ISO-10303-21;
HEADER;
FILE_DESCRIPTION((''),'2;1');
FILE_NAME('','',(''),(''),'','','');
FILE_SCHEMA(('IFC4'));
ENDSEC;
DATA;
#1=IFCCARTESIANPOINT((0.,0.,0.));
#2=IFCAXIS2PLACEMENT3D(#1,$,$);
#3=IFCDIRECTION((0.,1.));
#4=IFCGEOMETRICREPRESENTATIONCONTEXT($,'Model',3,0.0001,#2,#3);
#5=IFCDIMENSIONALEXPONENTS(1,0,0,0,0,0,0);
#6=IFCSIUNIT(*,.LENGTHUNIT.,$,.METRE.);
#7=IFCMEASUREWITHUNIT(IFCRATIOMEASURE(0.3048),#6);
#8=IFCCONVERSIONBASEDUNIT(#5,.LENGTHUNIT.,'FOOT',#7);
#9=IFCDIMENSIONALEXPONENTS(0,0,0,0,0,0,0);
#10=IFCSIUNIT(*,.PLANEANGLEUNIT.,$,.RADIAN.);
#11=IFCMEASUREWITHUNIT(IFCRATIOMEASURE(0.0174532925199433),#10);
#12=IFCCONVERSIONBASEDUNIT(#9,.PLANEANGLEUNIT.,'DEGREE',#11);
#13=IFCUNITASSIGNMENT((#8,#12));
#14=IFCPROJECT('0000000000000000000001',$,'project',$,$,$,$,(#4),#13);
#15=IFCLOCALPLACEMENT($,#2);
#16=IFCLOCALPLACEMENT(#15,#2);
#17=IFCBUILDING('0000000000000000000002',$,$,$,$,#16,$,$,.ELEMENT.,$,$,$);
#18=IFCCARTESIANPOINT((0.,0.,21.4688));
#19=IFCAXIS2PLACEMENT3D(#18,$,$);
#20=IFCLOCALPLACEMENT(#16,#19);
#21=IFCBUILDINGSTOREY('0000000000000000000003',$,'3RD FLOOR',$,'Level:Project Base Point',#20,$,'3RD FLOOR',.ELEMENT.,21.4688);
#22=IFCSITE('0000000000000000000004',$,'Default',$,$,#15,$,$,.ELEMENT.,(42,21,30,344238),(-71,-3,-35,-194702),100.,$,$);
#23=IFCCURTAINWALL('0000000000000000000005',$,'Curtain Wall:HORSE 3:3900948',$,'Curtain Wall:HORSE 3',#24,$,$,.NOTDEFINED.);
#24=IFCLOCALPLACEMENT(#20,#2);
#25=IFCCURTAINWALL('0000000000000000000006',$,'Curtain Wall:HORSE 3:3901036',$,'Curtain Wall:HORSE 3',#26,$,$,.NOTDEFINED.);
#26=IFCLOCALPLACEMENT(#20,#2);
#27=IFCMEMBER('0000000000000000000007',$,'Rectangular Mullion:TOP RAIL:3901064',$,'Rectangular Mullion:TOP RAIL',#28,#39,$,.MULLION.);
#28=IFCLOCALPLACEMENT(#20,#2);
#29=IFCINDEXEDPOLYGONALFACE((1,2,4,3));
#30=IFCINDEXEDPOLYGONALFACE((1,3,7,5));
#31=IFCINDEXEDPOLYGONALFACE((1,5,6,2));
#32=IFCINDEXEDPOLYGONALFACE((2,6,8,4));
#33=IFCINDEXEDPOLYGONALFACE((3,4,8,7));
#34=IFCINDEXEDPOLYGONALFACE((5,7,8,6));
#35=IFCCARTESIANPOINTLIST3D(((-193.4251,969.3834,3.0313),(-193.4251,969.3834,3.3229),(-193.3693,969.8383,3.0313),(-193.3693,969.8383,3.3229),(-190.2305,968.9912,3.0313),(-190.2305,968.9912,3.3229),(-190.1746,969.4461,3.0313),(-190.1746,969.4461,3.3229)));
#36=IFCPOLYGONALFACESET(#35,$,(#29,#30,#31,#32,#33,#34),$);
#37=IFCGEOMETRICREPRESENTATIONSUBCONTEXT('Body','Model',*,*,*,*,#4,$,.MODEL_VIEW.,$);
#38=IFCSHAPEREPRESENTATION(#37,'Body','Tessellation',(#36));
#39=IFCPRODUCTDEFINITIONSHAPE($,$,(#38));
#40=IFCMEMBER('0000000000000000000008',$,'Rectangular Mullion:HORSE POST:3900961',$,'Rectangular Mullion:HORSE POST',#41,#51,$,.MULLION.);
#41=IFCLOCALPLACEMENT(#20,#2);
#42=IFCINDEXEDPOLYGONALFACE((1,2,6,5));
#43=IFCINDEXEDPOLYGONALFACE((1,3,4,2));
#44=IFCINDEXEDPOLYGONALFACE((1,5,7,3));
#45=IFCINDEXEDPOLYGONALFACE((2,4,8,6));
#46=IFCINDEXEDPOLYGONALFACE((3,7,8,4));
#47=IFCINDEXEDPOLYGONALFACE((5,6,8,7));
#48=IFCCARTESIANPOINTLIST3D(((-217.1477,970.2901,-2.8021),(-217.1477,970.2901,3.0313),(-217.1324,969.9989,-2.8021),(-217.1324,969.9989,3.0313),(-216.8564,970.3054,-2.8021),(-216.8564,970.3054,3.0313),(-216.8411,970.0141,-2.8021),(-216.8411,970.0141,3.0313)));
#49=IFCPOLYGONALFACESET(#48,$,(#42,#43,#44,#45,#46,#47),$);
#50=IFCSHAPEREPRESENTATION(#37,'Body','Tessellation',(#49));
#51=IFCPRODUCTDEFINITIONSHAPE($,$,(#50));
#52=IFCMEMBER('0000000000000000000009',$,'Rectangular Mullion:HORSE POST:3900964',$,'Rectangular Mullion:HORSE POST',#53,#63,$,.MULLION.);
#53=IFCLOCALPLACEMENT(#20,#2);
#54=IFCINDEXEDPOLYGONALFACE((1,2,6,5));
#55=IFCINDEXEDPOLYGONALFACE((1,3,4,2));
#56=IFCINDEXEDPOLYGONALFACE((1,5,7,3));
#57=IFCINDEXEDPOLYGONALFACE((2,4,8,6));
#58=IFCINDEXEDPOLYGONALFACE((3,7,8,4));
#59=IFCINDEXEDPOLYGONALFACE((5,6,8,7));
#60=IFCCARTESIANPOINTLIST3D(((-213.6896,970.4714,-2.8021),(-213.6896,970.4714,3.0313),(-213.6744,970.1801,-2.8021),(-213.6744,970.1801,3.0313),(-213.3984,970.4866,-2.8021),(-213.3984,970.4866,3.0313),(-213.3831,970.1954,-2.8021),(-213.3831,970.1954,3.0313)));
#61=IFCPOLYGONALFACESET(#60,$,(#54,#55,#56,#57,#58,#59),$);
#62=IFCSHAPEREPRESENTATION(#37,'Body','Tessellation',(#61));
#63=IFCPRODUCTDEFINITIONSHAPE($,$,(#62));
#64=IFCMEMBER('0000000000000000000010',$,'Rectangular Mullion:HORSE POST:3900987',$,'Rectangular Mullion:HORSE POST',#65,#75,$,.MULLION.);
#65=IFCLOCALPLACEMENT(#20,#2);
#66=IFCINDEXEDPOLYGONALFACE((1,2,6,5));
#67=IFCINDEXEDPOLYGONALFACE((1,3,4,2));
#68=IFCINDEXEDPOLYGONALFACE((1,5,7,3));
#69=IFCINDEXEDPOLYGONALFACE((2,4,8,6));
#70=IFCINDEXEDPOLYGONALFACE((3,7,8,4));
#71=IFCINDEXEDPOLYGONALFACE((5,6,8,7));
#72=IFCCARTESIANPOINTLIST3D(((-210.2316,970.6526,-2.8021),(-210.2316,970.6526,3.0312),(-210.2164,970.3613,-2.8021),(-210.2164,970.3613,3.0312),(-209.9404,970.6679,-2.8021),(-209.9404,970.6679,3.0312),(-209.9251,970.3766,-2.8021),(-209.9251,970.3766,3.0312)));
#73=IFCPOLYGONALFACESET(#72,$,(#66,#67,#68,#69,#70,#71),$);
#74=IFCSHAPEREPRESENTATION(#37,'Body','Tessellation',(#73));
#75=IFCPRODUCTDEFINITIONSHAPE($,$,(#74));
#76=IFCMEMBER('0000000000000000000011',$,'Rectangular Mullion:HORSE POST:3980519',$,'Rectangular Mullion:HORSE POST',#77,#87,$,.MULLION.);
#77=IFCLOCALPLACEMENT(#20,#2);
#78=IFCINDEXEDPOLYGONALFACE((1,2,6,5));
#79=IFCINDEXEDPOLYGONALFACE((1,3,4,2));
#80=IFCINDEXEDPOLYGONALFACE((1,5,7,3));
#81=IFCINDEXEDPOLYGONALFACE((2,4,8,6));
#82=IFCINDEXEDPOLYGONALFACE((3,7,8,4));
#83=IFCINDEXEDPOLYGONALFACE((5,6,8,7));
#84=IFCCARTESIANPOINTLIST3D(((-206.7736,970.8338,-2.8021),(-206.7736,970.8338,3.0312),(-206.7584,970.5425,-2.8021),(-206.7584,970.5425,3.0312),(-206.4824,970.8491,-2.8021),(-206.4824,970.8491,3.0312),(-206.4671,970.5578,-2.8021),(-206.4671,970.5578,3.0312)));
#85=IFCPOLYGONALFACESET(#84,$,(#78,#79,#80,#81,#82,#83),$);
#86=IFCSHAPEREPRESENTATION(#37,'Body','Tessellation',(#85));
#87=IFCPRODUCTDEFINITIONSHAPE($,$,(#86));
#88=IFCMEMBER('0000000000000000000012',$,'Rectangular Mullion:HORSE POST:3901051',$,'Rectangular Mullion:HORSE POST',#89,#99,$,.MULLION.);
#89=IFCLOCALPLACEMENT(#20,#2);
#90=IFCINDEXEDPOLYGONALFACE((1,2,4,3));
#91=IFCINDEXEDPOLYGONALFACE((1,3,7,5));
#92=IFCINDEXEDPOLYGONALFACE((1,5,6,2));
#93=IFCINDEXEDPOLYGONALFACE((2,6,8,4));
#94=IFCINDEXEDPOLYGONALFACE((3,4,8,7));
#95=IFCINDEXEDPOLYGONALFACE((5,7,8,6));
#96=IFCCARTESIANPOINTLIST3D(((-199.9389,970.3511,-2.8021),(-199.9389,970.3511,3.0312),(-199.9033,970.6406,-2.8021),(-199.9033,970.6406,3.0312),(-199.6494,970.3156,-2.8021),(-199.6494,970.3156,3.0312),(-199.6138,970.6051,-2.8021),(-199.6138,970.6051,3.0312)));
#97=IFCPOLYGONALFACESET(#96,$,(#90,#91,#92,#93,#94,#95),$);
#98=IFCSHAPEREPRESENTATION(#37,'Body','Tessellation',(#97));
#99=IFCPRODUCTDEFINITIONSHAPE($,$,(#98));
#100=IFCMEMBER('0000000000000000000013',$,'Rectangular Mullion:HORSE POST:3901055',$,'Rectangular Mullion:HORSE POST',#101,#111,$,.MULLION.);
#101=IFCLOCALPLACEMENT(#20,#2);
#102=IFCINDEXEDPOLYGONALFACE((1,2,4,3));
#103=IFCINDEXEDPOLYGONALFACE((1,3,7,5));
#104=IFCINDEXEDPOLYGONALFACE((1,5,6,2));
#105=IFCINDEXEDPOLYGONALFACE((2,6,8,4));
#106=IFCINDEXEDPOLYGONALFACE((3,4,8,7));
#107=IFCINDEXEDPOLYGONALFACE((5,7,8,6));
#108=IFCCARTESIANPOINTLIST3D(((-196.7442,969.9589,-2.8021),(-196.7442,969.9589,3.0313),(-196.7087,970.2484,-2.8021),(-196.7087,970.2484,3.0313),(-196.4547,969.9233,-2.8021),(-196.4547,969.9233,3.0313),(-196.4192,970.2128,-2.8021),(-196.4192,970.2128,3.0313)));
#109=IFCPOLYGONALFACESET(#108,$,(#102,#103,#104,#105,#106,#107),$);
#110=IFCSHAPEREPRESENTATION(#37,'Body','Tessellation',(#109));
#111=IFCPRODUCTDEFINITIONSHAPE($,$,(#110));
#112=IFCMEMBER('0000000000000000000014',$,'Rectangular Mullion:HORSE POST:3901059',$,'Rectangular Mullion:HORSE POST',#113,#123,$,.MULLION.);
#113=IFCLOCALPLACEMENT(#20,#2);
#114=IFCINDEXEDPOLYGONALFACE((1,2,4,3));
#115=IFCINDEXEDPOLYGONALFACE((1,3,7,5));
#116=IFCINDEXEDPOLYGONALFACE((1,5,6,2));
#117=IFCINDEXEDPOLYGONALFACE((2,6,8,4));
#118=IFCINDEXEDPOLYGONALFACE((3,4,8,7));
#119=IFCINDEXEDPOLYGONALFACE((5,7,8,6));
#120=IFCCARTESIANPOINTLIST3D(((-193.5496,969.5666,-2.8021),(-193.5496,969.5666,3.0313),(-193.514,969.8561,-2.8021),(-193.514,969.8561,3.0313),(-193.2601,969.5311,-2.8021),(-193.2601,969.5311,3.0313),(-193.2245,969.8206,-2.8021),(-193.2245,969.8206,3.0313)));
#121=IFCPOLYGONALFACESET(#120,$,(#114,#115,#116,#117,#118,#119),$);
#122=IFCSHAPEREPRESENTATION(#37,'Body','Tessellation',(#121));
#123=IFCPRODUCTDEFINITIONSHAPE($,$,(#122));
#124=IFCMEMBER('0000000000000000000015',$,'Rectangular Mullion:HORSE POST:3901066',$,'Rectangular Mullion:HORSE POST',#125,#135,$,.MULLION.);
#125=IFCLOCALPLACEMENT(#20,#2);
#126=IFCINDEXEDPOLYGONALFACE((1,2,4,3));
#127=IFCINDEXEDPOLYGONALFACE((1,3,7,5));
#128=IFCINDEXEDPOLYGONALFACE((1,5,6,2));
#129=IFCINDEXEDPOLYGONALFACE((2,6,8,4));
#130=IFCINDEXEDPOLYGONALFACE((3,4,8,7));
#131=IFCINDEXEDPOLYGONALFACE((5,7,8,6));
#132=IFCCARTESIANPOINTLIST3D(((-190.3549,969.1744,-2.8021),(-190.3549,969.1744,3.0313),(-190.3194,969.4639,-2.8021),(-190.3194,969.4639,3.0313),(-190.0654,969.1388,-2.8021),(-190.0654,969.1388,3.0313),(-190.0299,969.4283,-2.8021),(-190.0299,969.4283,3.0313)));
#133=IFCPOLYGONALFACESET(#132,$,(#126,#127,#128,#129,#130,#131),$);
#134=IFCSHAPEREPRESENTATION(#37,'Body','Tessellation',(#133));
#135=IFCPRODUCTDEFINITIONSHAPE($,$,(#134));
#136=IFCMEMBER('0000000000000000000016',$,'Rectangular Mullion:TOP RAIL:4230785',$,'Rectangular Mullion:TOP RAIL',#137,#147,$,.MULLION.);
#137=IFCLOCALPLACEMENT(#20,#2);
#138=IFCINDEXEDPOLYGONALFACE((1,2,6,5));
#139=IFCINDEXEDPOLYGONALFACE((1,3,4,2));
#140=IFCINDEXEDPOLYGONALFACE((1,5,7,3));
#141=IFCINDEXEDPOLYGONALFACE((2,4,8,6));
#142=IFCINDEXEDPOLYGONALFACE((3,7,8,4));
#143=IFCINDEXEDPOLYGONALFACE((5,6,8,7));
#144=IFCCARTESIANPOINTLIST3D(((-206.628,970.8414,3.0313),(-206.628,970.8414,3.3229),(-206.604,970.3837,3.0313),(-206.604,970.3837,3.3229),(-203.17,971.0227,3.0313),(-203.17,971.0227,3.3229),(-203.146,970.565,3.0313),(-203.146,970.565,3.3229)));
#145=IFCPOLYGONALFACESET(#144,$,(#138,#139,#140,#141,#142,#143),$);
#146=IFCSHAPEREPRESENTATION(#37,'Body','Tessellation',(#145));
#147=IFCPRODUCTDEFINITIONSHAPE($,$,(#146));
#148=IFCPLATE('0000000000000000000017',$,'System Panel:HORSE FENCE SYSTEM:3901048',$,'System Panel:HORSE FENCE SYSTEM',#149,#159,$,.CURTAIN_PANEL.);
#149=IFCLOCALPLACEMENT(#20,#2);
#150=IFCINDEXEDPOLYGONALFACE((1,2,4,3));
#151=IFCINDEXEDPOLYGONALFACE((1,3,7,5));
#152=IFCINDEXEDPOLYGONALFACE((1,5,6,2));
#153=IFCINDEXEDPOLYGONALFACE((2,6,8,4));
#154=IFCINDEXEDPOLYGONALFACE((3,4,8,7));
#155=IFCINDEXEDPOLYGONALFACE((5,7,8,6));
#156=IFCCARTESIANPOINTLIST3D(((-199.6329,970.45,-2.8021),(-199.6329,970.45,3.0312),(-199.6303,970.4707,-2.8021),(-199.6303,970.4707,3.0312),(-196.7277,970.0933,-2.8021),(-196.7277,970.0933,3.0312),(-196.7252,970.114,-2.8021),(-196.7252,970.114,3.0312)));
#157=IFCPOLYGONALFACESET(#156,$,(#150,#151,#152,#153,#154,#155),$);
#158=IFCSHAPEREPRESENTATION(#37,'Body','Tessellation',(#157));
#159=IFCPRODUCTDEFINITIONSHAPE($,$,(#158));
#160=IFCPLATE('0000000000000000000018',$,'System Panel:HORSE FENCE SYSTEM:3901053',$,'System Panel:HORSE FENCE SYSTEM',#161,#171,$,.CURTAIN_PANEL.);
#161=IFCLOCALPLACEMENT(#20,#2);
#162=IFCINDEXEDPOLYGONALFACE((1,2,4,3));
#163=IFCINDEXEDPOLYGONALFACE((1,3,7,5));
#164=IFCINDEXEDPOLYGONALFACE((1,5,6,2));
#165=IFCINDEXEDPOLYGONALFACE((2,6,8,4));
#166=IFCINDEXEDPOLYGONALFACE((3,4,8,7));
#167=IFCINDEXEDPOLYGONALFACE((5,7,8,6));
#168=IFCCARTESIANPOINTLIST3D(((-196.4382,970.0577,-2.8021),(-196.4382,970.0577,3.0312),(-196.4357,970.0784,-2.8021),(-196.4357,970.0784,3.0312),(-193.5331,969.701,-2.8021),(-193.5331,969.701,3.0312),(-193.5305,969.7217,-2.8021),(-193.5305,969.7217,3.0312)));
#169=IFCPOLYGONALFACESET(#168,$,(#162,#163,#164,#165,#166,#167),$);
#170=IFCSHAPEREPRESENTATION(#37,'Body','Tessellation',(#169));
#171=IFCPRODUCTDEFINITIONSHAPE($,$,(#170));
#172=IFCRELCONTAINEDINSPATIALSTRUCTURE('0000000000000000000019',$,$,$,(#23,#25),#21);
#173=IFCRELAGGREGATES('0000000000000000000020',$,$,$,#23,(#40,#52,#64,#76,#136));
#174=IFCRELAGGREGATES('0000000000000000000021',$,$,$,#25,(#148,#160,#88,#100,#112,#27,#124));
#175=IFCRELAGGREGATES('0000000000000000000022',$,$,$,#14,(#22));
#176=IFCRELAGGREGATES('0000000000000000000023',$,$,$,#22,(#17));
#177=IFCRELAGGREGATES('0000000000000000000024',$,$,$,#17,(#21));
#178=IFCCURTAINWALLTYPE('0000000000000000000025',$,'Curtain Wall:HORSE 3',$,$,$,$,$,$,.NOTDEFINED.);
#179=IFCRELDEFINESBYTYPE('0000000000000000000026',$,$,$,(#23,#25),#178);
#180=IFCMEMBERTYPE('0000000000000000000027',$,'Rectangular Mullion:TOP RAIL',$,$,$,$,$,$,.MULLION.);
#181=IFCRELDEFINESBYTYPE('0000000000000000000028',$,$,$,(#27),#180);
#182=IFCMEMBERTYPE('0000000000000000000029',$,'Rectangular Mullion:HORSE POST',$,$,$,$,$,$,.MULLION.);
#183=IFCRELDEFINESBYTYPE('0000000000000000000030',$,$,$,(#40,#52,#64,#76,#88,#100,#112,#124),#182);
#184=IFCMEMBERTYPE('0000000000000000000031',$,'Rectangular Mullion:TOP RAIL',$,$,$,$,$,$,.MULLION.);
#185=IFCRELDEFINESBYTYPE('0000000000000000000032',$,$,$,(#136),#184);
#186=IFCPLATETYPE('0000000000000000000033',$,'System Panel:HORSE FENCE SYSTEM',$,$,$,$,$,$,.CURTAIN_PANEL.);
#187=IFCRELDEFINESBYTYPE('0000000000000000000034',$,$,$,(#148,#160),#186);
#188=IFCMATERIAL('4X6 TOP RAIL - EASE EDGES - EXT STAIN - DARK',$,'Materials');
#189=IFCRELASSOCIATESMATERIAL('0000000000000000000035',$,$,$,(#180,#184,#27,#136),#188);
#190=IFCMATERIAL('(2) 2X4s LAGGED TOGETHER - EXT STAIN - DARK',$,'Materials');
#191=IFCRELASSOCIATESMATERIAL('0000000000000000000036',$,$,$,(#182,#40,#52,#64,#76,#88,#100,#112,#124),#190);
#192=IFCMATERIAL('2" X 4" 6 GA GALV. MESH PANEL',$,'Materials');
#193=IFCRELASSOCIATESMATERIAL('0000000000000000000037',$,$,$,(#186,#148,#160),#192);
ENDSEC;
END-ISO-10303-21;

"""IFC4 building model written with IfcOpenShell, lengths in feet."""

from ifc_helpers import new_model, entity, si_unit, converted_unit, direction, frame, frame_2d, origin, origin_2d_with_axis, place, context, subcontext, project, spatial, rectangle, extrude, source, transform, mapped, material, material_profile, profile_set, profile_usage, type_object, type_shapes, element, aggregate, save


model = new_model("IFC4")

# Units and contexts
model_context = context("Model", 3, precision=0.0001, world=origin(), true_north=direction((0.0, 1.0)))
body_context = subcontext(model_context, "Body", "Model", "MODEL_VIEW")
ifc_project = project(units=[converted_unit("LENGTHUNIT", "FOOT", entity("IfcRatioMeasure", 0.3048), si_unit("LENGTHUNIT", "METRE"), dimensions=[1, 0, 0, 0, 0, 0, 0]), converted_unit("PLANEANGLEUNIT", "DEGREE", entity("IfcRatioMeasure", 0.0174532925199433), si_unit("PLANEANGLEUNIT", "RADIAN"), dimensions=[0, 0, 0, 0, 0, 0, 0])], contexts=[model_context])

# Site, building, storey
site_placement = place(None, origin())
site = spatial("IfcSite", under=ifc_project, at=site_placement, Name="Default", CompositionType="ELEMENT", RefLatitude=(42, 21, 30, 344238), RefLongitude=(-71, -3, -35, -194702), RefElevation=100.0)
building_placement = place(site_placement, origin())
building = spatial("IfcBuilding", under=site, at=building_placement, CompositionType="ELEMENT")
storey_placement = place(building_placement, frame((0.0, 0.0, 21.4688)))
storey = spatial("IfcBuildingStorey", under=building, at=storey_placement, Name="3RD FLOOR", ObjectType="Level:Project Base Point", LongName="3RD FLOOR", CompositionType="ELEMENT", Elevation=21.4688)

# Curtain walls
curtain_wall_type_1 = type_object("IfcCurtainWallType", Name="Curtain Wall:HORSE 3", PredefinedType="NOTDEFINED")
curtain_wall_1_placement = place(storey_placement, frame((0.0, 0.0, -21.4688)))
curtain_wall_1 = element("IfcCurtainWall", 1, at=curtain_wall_1_placement, inside=storey, type_object=curtain_wall_type_1, Name="Curtain Wall:HORSE 3:3900948", ObjectType="Curtain Wall:HORSE 3", PredefinedType="NOTDEFINED")
ifc_material_1 = material(Name="(2) 2X4s LAGGED TOGETHER - EXT STAIN - DARK", Category="Materials")
ifc_material_profile_1 = material_profile(ifc_material_1, rectangle(XDim=0.2917, YDim=0.2917, at=frame_2d((0.0, 0.0), x_axis=(1.0, 0.0))), Name="HORSE POST")
ifc_profile_set_1 = profile_set([ifc_material_profile_1], Name="HORSE POST")
curtain_wall_2_placement = place(storey_placement, frame((0.0, 0.0, -21.4688)))
curtain_wall_2 = element("IfcCurtainWall", 2, at=curtain_wall_2_placement, inside=storey, type_object=curtain_wall_type_1, Name="Curtain Wall:HORSE 3:3901036", ObjectType="Curtain Wall:HORSE 3", PredefinedType="NOTDEFINED")

# Members
ifc_material_2 = material(Name="4X6 TOP RAIL - EASE EDGES - EXT STAIN - DARK", Category="Materials")
ifc_material_profile_2 = material_profile(ifc_material_2, rectangle(XDim=0.4583, YDim=0.2917, at=origin_2d_with_axis()), Name="TOP RAIL")
ifc_profile_set_2 = profile_set([ifc_material_profile_2], Name="TOP RAIL")
member_type_1 = type_object("IfcMemberType", Name="Rectangular Mullion:TOP RAIL", PredefinedType="MULLION", material=ifc_profile_set_2)
shared_shape_1 = source(origin(), body_context, "Body", "SweptSolid", [
    extrude(rectangle(XDim=0.4583, YDim=0.2917, at=origin_2d_with_axis()), frame((-0.1458, -0.0625, -3.2186), z_axis=(0.0, 0.0, 1.0), x_axis=(0.0, -1.0, 0.0)), (0.0, 0.0, 1.0), 3.2186),
])
type_shapes(member_type_1, [shared_shape_1])
ifc_profile_usage_1 = profile_usage(ifc_profile_set_2)
member_1_placement = place(storey_placement, frame((-190.2102, 969.1566, 3.3229), z_axis=(0.992546, -0.121869, 0.0), x_axis=(0.0, 0.0, 1.0)))
member_1 = element("IfcMember", 3, at=member_1_placement, type_object=member_type_1, material=ifc_profile_usage_1, Name="Rectangular Mullion:TOP RAIL:3901064", ObjectType="Rectangular Mullion:TOP RAIL", PredefinedType="MULLION", context=body_context, shape_type="MappedRepresentation", body=[
    mapped(shared_shape_1, transform((0.0, 0.0, 0.0), scale=1.0)),
])
ifc_profile_usage_2 = profile_usage(ifc_profile_set_1)
member_type_2 = type_object("IfcMemberType", Name="Rectangular Mullion:HORSE POST", PredefinedType="MULLION", material=ifc_profile_set_1)
shared_shape_2 = source(origin(), body_context, "Body", "SweptSolid", [
    extrude(rectangle(XDim=0.2917, YDim=0.2917, at=frame_2d((0.0, 0.0), x_axis=(1.0, 0.0))), frame((0.0, -0.1458, -5.8333), z_axis=(0.0, 0.0, 1.0), x_axis=(0.0, -1.0, 0.0)), (0.0, 0.0, 1.0), 5.8333),
])
type_shapes(member_type_2, [shared_shape_2])
member_2_placement = place(storey_placement, frame((-216.9868, 970.0065, -2.8021), z_axis=(0.0, 0.0, -1.0), x_axis=(0.99863, 0.052336, 0.0)))
member_2 = element("IfcMember", 4, at=member_2_placement, type_object=member_type_2, material=ifc_profile_usage_2, Name="Rectangular Mullion:HORSE POST:3900961", ObjectType="Rectangular Mullion:HORSE POST", PredefinedType="MULLION", context=body_context, shape_type="MappedRepresentation", body=[
    mapped(shared_shape_2, transform((0.0, 0.0, 0.0), scale=1.0)),
])
ifc_profile_usage_3 = profile_usage(ifc_profile_set_1)
member_3_placement = place(storey_placement, frame((-213.5287, 970.1877, -2.8021), z_axis=(0.0, 0.0, -1.0), x_axis=(0.99863, 0.052336, 0.0)))
member_3 = element("IfcMember", 5, at=member_3_placement, type_object=member_type_2, material=ifc_profile_usage_3, Name="Rectangular Mullion:HORSE POST:3900964", ObjectType="Rectangular Mullion:HORSE POST", PredefinedType="MULLION", context=body_context, shape_type="MappedRepresentation", body=[
    mapped(shared_shape_2, transform((0.0, 0.0, 0.0), scale=1.0)),
])
ifc_profile_usage_4 = profile_usage(ifc_profile_set_1)
placement = place(building_placement, frame((0.0, 0.0, 10.8021)))
member_4_placement = place(placement, frame((-210.0707, 970.369, 7.8646), z_axis=(0.0, 0.0, -1.0), x_axis=(0.99863, 0.052336, 0.0)))
member_4 = element("IfcMember", 6, at=member_4_placement, type_object=member_type_2, material=ifc_profile_usage_4, Name="Rectangular Mullion:HORSE POST:3900987", ObjectType="Rectangular Mullion:HORSE POST", PredefinedType="MULLION", context=body_context, shape_type="MappedRepresentation", body=[
    mapped(shared_shape_2, transform((0.0, 0.0, 0.0), scale=1.0)),
])
ifc_profile_usage_5 = profile_usage(ifc_profile_set_1)
member_5_placement = place(placement, frame((-206.6127, 970.5502, 7.8646), z_axis=(0.0, 0.0, -1.0), x_axis=(0.99863, 0.052336, 0.0)))
member_5 = element("IfcMember", 7, at=member_5_placement, type_object=member_type_2, material=ifc_profile_usage_5, Name="Rectangular Mullion:HORSE POST:3980519", ObjectType="Rectangular Mullion:HORSE POST", PredefinedType="MULLION", context=body_context, shape_type="MappedRepresentation", body=[
    mapped(shared_shape_2, transform((0.0, 0.0, 0.0), scale=1.0)),
])
ifc_profile_usage_6 = profile_usage(ifc_profile_set_1)
member_6_placement = place(storey_placement, frame((-199.7941, 970.3334, -2.8021), z_axis=(0.0, 0.0, -1.0), x_axis=(0.992546, -0.121869, 0.0)))
member_6 = element("IfcMember", 8, at=member_6_placement, type_object=member_type_2, material=ifc_profile_usage_6, Name="Rectangular Mullion:HORSE POST:3901051", ObjectType="Rectangular Mullion:HORSE POST", PredefinedType="MULLION", context=body_context, shape_type="MappedRepresentation", body=[
    mapped(shared_shape_2, transform((0.0, 0.0, 0.0), scale=1.0)),
])
ifc_profile_usage_7 = profile_usage(ifc_profile_set_1)
member_7_placement = place(storey_placement, frame((-196.5995, 969.9411, -2.8021), z_axis=(0.0, 0.0, -1.0), x_axis=(0.992546, -0.121869, 0.0)))
member_7 = element("IfcMember", 9, at=member_7_placement, type_object=member_type_2, material=ifc_profile_usage_7, Name="Rectangular Mullion:HORSE POST:3901055", ObjectType="Rectangular Mullion:HORSE POST", PredefinedType="MULLION", context=body_context, shape_type="MappedRepresentation", body=[
    mapped(shared_shape_2, transform((0.0, 0.0, 0.0), scale=1.0)),
])
ifc_profile_usage_8 = profile_usage(ifc_profile_set_1)
member_8_placement = place(storey_placement, frame((-193.4048, 969.5489, -2.8021), z_axis=(0.0, 0.0, -1.0), x_axis=(0.992546, -0.121869, 0.0)))
member_8 = element("IfcMember", 10, at=member_8_placement, type_object=member_type_2, material=ifc_profile_usage_8, Name="Rectangular Mullion:HORSE POST:3901059", ObjectType="Rectangular Mullion:HORSE POST", PredefinedType="MULLION", context=body_context, shape_type="MappedRepresentation", body=[
    mapped(shared_shape_2, transform((0.0, 0.0, 0.0), scale=1.0)),
])
ifc_profile_usage_9 = profile_usage(ifc_profile_set_1)
member_9_placement = place(storey_placement, frame((-190.2102, 969.1566, -2.8021), z_axis=(0.0, 0.0, -1.0), x_axis=(0.992546, -0.121869, 0.0)))
member_9 = element("IfcMember", 11, at=member_9_placement, type_object=member_type_2, material=ifc_profile_usage_9, Name="Rectangular Mullion:HORSE POST:3901066", ObjectType="Rectangular Mullion:HORSE POST", PredefinedType="MULLION", context=body_context, shape_type="MappedRepresentation", body=[
    mapped(shared_shape_2, transform((0.0, 0.0, 0.0), scale=1.0)),
])
ifc_profile_usage_10 = profile_usage(ifc_profile_set_2)
member_type_3 = type_object("IfcMemberType", Name="Rectangular Mullion:TOP RAIL", PredefinedType="MULLION", material=ifc_profile_set_2)
shared_shape_3 = source(origin(), body_context, "Body", "SweptSolid", [
    extrude(rectangle(XDim=0.4583, YDim=0.2917, at=origin_2d_with_axis()), frame((-0.1458, -0.0625, -3.4628), z_axis=(0.0, 0.0, 1.0), x_axis=(0.0, -1.0, 0.0)), (0.0, 0.0, 1.0), 3.4628),
])
type_shapes(member_type_3, [shared_shape_3])
member_10_placement = place(storey_placement, frame((-203.1547, 970.7314, 3.3229), z_axis=(0.99863, 0.052336, 0.0), x_axis=(0.0, 0.0, 1.0)))
member_10 = element("IfcMember", 12, at=member_10_placement, type_object=member_type_3, material=ifc_profile_usage_10, Name="Rectangular Mullion:TOP RAIL:4230785", ObjectType="Rectangular Mullion:TOP RAIL", PredefinedType="MULLION", context=body_context, shape_type="MappedRepresentation", body=[
    mapped(shared_shape_3, transform((0.0, 0.0, 0.0), scale=1.0)),
])

# Plates
ifc_material_3 = material(Name="2\" X 4\" 6 GA GALV. MESH PANEL", Category="Materials")
plate_type_1 = type_object("IfcPlateType", Name="System Panel:HORSE FENCE SYSTEM", PredefinedType="CURTAIN_PANEL", material=ifc_material_3)
shared_shape_4 = source(origin(), body_context, "Body", "SweptSolid", [
    extrude(rectangle(XDim=0.0208, YDim=2.927, at=frame_2d((0.0, 0.0), x_axis=(1.0, 0.0))), frame((1.4635, 0.0104, 0.0), z_axis=(0.0, 0.0, 1.0), x_axis=(0.0, 1.0, 0.0)), (0.0, 0.0, 1.0), 5.8333),
])
type_shapes(plate_type_1, [shared_shape_4])
plate_1_placement = place(curtain_wall_2_placement, frame((-199.6329, 970.45, 18.6667), z_axis=(0.0, 0.0, 1.0), x_axis=(0.992546, -0.121869, 0.0)))
plate_1 = element("IfcPlate", 13, at=plate_1_placement, type_object=plate_type_1, material=ifc_material_3, Name="System Panel:HORSE FENCE SYSTEM:3901048", ObjectType="System Panel:HORSE FENCE SYSTEM", PredefinedType="CURTAIN_PANEL", context=body_context, shape_type="MappedRepresentation", body=[
    mapped(shared_shape_4, transform((0.0, 0.0, 0.0), scale=1.0)),
])
plate_2_placement = place(curtain_wall_2_placement, frame((-196.4382, 970.0577, 18.6667), z_axis=(0.0, 0.0, 1.0), x_axis=(0.992546, -0.121869, 0.0)))
plate_2 = element("IfcPlate", 14, at=plate_2_placement, type_object=plate_type_1, material=ifc_material_3, Name="System Panel:HORSE FENCE SYSTEM:3901053", ObjectType="System Panel:HORSE FENCE SYSTEM", PredefinedType="CURTAIN_PANEL", context=body_context, shape_type="MappedRepresentation", body=[
    mapped(shared_shape_4, transform((0.0, 0.0, 0.0), scale=1.0)),
])
aggregate(curtain_wall_1, [member_2, member_3, member_4, member_5, member_10])
aggregate(curtain_wall_2, [plate_1, plate_2, member_6, member_7, member_8, member_1, member_9])

save(model, "model.ifc")
